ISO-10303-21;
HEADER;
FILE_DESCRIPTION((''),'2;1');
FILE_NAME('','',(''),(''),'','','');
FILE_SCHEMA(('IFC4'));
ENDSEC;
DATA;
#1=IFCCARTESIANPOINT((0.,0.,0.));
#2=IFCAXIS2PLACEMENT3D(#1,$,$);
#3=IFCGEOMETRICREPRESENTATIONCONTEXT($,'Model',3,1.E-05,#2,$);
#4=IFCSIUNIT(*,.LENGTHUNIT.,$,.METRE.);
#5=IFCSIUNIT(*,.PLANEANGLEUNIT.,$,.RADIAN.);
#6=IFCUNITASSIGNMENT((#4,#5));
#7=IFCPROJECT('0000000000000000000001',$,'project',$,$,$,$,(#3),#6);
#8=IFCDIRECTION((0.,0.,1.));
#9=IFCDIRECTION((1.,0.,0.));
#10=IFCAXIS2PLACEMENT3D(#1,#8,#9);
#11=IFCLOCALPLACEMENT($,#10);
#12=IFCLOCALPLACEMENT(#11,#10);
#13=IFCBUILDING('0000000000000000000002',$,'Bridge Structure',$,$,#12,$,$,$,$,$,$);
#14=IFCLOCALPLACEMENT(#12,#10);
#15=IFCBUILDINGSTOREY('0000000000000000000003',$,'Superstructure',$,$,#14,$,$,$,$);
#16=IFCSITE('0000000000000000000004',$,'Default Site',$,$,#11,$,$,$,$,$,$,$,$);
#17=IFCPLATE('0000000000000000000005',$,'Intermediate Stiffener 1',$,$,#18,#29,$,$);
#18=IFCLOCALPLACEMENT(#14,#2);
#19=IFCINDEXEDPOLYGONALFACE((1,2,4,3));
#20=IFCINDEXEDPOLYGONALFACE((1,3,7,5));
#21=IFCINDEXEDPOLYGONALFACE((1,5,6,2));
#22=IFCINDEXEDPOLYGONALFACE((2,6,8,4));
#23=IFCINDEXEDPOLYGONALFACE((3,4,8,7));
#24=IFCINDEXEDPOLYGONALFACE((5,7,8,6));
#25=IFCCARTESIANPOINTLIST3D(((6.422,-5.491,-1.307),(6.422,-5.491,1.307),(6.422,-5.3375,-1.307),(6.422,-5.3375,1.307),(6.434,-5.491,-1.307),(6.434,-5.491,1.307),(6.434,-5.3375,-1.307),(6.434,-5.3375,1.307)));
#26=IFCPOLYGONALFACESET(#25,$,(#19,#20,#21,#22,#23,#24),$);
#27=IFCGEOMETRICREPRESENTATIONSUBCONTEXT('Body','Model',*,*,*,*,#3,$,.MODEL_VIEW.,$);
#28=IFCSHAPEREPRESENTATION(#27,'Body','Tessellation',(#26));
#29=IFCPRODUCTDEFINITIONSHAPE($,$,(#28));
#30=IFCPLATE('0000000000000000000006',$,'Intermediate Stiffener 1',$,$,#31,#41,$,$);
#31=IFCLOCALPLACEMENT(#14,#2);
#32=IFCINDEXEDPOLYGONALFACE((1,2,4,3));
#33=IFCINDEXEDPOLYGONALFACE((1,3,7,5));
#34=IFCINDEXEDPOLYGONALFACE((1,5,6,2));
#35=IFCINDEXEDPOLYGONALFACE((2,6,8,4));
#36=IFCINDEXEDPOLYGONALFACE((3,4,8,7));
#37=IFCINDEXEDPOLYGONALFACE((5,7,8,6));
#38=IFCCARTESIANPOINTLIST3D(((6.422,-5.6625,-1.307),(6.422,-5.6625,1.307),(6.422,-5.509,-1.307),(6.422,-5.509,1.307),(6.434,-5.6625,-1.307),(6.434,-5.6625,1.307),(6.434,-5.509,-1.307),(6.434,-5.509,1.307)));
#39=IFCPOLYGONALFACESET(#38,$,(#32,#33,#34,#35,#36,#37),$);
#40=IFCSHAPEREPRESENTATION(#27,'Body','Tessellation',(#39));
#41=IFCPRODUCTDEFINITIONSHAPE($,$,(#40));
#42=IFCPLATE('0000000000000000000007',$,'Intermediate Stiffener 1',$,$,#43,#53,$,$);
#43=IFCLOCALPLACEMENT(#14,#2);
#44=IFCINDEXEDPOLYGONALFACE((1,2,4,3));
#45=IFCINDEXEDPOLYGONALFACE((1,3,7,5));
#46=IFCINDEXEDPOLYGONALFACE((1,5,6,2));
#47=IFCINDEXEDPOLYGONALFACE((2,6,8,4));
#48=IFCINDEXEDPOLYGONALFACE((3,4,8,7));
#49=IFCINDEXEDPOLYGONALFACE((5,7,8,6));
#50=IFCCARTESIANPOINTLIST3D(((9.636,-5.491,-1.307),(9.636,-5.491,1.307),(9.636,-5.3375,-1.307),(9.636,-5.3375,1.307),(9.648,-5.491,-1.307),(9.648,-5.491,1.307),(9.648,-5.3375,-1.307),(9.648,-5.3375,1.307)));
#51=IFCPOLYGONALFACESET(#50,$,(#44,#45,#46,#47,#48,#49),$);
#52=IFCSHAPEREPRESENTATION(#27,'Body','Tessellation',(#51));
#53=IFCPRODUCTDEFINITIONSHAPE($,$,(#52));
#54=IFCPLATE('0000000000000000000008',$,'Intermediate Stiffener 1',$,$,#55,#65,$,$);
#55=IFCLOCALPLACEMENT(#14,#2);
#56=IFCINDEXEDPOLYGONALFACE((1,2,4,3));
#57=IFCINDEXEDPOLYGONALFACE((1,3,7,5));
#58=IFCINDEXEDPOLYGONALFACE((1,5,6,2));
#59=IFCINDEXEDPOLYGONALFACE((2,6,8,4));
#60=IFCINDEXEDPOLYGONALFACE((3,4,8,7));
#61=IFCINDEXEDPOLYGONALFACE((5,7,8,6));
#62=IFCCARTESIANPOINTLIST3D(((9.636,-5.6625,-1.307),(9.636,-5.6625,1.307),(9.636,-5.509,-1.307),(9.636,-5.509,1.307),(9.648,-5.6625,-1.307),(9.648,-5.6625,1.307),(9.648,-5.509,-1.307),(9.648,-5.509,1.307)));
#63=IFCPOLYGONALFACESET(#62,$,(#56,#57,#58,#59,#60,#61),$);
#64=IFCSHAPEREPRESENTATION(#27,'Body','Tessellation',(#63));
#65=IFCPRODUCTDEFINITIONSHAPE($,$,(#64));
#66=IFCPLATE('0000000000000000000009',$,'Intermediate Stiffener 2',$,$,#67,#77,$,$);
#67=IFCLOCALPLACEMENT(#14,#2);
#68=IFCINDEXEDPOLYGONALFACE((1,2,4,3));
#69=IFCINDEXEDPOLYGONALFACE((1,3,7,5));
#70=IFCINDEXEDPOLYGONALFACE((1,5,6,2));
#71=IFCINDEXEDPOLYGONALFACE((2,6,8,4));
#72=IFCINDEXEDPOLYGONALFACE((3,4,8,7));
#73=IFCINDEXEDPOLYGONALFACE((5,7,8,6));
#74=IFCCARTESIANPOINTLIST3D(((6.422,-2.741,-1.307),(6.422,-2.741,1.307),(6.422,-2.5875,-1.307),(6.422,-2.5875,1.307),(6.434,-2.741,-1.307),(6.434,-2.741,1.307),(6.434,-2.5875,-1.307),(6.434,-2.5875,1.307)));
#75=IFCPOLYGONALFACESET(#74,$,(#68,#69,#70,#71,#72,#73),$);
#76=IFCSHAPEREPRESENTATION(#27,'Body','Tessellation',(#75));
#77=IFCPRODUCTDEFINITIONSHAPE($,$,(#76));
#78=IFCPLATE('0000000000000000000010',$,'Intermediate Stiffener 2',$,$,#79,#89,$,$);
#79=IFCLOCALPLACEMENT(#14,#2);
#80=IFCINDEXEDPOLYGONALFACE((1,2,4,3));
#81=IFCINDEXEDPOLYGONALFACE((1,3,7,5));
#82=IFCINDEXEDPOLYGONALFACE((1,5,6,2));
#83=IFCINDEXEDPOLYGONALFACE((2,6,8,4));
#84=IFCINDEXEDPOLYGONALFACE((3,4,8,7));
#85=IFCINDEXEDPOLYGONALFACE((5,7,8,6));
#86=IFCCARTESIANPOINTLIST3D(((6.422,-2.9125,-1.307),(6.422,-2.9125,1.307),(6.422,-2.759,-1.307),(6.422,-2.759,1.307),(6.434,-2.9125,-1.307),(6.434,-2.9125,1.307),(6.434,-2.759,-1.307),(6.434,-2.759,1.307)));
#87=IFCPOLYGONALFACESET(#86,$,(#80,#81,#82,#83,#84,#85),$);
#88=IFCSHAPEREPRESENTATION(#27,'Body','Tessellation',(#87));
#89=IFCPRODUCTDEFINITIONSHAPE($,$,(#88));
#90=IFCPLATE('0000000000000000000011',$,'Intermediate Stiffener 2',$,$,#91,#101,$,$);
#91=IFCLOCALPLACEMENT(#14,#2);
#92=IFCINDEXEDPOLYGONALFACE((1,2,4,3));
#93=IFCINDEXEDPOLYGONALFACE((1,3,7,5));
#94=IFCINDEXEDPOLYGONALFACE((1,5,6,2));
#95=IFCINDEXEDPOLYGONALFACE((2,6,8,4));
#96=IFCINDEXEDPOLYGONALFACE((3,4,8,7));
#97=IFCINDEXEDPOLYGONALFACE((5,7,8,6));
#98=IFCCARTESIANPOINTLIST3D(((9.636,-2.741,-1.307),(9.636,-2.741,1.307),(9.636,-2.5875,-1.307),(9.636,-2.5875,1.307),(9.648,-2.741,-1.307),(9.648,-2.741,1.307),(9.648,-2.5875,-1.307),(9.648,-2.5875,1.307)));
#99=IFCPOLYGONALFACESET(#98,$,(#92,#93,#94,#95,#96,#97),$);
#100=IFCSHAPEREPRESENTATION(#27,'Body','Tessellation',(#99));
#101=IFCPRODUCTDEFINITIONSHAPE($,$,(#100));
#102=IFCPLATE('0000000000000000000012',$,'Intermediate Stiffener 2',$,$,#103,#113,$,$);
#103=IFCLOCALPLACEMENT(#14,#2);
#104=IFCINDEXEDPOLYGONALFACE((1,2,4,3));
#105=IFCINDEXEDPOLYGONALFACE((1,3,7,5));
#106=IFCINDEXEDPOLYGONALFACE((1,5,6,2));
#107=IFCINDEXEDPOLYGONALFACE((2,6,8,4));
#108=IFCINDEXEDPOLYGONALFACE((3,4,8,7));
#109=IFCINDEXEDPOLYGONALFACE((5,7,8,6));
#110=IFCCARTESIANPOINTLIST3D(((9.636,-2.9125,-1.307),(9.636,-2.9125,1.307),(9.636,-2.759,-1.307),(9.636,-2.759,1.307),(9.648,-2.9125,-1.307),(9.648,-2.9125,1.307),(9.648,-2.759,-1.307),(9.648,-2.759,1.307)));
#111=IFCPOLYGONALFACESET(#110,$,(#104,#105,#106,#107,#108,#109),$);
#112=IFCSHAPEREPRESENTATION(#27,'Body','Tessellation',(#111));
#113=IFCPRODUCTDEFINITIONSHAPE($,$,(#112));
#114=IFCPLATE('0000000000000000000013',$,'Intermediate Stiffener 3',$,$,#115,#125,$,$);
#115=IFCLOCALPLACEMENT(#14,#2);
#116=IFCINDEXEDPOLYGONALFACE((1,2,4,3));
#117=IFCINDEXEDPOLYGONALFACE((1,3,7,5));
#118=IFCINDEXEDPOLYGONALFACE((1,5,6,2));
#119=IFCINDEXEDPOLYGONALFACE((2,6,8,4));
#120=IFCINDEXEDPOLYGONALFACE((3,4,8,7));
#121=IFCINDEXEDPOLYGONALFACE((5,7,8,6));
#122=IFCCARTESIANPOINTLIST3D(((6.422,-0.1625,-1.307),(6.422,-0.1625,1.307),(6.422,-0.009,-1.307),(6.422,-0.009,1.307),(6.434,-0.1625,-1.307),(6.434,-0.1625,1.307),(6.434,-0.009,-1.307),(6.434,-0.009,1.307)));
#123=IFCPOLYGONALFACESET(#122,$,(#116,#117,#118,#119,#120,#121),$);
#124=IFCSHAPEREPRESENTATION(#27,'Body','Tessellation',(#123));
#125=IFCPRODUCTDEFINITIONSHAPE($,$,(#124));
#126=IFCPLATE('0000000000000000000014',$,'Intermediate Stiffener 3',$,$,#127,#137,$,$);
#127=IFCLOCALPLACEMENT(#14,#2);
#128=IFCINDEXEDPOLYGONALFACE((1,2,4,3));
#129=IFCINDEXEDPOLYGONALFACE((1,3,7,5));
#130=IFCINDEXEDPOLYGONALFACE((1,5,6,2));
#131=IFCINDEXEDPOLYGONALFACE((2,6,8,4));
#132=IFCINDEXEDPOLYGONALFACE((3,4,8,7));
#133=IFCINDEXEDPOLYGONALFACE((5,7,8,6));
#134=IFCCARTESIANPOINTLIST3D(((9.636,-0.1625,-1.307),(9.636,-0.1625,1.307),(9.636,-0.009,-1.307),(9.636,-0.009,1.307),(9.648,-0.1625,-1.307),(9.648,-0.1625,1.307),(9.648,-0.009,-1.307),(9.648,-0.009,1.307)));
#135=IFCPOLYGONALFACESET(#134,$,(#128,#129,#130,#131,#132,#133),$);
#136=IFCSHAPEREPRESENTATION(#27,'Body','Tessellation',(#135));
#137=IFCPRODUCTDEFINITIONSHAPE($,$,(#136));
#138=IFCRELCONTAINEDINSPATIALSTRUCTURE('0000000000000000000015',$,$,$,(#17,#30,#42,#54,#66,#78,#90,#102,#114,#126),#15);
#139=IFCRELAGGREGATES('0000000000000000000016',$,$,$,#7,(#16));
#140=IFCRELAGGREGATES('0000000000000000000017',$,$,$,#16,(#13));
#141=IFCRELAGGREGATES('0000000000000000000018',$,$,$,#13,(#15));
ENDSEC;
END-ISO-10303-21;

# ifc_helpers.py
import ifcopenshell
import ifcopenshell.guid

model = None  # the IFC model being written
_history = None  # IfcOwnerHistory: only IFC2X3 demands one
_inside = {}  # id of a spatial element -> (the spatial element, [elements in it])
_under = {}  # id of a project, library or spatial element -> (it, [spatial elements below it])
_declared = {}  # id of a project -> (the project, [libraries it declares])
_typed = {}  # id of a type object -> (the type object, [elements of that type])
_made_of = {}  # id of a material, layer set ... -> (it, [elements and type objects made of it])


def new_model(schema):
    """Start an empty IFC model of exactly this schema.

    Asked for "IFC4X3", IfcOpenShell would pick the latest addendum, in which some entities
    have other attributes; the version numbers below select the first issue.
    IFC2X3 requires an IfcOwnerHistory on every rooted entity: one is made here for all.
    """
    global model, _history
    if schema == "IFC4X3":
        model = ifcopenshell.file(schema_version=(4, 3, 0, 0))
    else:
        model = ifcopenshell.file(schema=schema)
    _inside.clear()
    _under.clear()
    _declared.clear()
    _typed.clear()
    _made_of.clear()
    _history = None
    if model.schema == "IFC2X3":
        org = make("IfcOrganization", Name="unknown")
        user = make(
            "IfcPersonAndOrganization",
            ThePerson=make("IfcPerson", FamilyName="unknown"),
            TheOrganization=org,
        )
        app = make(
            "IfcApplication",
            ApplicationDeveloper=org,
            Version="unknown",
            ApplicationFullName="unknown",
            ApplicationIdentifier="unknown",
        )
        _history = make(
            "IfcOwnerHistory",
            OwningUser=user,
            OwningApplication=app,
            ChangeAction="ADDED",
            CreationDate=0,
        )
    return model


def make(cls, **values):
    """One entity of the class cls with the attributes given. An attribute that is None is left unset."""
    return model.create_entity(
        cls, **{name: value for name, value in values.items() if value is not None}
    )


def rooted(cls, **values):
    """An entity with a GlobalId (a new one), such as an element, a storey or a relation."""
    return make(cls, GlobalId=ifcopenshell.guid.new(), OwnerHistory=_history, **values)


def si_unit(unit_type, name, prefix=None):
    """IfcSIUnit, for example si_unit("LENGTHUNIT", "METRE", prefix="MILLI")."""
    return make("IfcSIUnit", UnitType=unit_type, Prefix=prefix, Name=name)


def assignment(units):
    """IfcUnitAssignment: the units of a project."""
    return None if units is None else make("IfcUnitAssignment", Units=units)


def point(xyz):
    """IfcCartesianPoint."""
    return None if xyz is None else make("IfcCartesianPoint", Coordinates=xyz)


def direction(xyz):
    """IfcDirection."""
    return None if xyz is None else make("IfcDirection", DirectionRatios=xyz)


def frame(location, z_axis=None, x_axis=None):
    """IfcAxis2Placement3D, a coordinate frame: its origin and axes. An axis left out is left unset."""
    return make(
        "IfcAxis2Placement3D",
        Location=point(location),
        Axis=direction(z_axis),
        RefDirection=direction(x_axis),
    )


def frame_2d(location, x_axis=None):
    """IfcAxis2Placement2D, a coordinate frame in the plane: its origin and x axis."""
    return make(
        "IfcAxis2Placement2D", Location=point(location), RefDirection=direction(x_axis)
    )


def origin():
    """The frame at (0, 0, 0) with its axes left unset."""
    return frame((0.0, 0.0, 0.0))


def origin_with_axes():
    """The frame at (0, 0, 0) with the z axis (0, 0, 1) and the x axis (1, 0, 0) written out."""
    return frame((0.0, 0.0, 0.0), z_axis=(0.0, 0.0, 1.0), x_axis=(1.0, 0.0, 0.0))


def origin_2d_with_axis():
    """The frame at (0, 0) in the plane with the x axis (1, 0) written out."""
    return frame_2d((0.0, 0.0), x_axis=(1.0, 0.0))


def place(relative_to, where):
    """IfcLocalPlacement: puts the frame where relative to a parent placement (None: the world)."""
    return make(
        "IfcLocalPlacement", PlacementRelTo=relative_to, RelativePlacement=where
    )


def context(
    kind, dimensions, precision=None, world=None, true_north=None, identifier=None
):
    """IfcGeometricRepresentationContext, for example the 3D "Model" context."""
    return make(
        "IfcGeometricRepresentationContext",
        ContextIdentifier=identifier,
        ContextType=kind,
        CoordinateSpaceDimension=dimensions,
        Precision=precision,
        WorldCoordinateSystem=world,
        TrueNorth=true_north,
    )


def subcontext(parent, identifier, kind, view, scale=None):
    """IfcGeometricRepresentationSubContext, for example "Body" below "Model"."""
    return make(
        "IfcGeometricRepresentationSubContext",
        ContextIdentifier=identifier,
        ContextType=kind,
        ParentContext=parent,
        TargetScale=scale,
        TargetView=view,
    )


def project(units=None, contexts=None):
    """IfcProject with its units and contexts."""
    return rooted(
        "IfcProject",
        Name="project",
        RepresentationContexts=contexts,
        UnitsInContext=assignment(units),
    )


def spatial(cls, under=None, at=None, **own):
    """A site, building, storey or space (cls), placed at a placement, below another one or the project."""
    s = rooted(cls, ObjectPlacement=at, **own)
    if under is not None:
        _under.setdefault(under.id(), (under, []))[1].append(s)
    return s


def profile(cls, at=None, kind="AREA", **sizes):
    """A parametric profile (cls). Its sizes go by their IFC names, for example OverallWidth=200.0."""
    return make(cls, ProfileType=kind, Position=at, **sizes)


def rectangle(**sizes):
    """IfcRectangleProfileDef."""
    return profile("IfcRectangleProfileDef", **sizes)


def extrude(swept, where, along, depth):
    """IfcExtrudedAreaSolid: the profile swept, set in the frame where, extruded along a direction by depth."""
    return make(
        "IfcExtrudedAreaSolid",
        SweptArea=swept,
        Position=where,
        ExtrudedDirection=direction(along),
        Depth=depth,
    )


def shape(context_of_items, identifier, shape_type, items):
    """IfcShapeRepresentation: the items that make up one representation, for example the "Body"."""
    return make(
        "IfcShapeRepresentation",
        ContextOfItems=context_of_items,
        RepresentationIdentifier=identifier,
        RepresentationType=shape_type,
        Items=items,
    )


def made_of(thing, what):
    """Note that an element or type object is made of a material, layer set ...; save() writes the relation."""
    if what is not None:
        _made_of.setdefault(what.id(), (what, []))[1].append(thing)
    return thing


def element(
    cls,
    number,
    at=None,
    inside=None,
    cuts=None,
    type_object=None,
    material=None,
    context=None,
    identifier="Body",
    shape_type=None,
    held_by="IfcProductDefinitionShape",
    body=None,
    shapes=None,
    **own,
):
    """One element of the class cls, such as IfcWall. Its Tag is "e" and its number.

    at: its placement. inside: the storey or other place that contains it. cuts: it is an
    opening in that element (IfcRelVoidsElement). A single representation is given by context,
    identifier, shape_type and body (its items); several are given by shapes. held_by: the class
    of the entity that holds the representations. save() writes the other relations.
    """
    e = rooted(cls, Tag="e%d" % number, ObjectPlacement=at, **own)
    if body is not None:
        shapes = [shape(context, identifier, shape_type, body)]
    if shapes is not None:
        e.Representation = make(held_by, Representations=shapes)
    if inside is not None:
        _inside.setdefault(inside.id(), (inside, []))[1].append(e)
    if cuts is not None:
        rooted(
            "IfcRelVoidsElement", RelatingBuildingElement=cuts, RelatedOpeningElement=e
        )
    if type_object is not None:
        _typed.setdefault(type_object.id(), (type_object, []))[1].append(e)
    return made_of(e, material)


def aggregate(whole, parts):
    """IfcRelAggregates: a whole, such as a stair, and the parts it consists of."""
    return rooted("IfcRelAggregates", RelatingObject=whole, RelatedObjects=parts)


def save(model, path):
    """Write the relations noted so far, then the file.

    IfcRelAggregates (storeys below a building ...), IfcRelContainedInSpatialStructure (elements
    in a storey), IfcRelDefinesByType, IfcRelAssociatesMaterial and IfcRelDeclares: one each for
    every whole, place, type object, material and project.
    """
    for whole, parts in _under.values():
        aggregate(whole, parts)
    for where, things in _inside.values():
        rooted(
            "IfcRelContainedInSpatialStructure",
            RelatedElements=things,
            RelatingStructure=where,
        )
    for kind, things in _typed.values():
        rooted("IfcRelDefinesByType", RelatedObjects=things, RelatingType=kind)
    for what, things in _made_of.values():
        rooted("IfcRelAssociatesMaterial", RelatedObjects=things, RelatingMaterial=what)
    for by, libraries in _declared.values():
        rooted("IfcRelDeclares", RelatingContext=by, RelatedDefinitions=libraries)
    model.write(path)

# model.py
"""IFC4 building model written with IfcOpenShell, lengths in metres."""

from ifc_helpers import new_model, si_unit, frame, origin, origin_with_axes, origin_2d_with_axis, place, context, subcontext, project, spatial, rectangle, extrude, element, save


model = new_model("IFC4")

# Units and contexts
model_context = context("Model", 3, precision=1e-05, world=origin())
body_context = subcontext(model_context, "Body", "Model", "MODEL_VIEW")
ifc_project = project(units=[si_unit("LENGTHUNIT", "METRE"), si_unit("PLANEANGLEUNIT", "RADIAN")], contexts=[model_context])

# Site, building, storey
site_placement = place(None, origin_with_axes())
site = spatial("IfcSite", under=ifc_project, at=site_placement, Name="Default Site")
building_placement = place(site_placement, origin_with_axes())
building = spatial("IfcBuilding", under=site, at=building_placement, Name="Bridge Structure")
storey_placement = place(building_placement, origin_with_axes())
storey = spatial("IfcBuildingStorey", under=building, at=storey_placement, Name="Superstructure")

# Plates
for number, where, z_axis, x_axis, name in (
    (1, (6.428, -5.4143, -1.307), (0.0, 0.0, 1.0), (1.0, 0.0, 0.0), "Intermediate Stiffener 1"),
    (2, (6.428, -5.5857, -1.307), (0.0, 0.0, 1.0), (1.0, 0.0, 0.0), "Intermediate Stiffener 1"),
    (3, (9.642, -5.4143, -1.307), (0.0, 0.0, 1.0), (1.0, 0.0, 0.0), "Intermediate Stiffener 1"),
    (4, (9.642, -5.5857, -1.307), (0.0, 0.0, 1.0), (1.0, 0.0, 0.0), "Intermediate Stiffener 1"),
    (5, (6.428, -2.6643, -1.307), (0.0, 0.0, 1.0), (1.0, 0.0, 0.0), "Intermediate Stiffener 2"),
    (6, (6.428, -2.8357, -1.307), (0.0, 0.0, 1.0), (1.0, 0.0, 0.0), "Intermediate Stiffener 2"),
    (7, (9.642, -2.6643, -1.307), (0.0, 0.0, 1.0), (1.0, 0.0, 0.0), "Intermediate Stiffener 2"),
    (8, (9.642, -2.8357, -1.307), (0.0, 0.0, 1.0), (1.0, 0.0, 0.0), "Intermediate Stiffener 2"),
    (9, (6.428, -0.0858, -1.307), (0.0, 0.0, 1.0), (1.0, 0.0, 0.0), "Intermediate Stiffener 3"),
    (10, (9.642, -0.0858, -1.307), (0.0, 0.0, 1.0), (1.0, 0.0, 0.0), "Intermediate Stiffener 3"),
):
    element("IfcPlate", number, at=place(storey_placement, frame(where, z_axis=z_axis, x_axis=x_axis)), inside=storey, Name=name, context=body_context, shape_type="SweptSolid", body=[
        extrude(rectangle(XDim=0.012, YDim=0.1535, at=origin_2d_with_axis()), origin_with_axes(), (0.0, 0.0, 1.0), 2.614),
    ])

save(model, "model.ifc")
